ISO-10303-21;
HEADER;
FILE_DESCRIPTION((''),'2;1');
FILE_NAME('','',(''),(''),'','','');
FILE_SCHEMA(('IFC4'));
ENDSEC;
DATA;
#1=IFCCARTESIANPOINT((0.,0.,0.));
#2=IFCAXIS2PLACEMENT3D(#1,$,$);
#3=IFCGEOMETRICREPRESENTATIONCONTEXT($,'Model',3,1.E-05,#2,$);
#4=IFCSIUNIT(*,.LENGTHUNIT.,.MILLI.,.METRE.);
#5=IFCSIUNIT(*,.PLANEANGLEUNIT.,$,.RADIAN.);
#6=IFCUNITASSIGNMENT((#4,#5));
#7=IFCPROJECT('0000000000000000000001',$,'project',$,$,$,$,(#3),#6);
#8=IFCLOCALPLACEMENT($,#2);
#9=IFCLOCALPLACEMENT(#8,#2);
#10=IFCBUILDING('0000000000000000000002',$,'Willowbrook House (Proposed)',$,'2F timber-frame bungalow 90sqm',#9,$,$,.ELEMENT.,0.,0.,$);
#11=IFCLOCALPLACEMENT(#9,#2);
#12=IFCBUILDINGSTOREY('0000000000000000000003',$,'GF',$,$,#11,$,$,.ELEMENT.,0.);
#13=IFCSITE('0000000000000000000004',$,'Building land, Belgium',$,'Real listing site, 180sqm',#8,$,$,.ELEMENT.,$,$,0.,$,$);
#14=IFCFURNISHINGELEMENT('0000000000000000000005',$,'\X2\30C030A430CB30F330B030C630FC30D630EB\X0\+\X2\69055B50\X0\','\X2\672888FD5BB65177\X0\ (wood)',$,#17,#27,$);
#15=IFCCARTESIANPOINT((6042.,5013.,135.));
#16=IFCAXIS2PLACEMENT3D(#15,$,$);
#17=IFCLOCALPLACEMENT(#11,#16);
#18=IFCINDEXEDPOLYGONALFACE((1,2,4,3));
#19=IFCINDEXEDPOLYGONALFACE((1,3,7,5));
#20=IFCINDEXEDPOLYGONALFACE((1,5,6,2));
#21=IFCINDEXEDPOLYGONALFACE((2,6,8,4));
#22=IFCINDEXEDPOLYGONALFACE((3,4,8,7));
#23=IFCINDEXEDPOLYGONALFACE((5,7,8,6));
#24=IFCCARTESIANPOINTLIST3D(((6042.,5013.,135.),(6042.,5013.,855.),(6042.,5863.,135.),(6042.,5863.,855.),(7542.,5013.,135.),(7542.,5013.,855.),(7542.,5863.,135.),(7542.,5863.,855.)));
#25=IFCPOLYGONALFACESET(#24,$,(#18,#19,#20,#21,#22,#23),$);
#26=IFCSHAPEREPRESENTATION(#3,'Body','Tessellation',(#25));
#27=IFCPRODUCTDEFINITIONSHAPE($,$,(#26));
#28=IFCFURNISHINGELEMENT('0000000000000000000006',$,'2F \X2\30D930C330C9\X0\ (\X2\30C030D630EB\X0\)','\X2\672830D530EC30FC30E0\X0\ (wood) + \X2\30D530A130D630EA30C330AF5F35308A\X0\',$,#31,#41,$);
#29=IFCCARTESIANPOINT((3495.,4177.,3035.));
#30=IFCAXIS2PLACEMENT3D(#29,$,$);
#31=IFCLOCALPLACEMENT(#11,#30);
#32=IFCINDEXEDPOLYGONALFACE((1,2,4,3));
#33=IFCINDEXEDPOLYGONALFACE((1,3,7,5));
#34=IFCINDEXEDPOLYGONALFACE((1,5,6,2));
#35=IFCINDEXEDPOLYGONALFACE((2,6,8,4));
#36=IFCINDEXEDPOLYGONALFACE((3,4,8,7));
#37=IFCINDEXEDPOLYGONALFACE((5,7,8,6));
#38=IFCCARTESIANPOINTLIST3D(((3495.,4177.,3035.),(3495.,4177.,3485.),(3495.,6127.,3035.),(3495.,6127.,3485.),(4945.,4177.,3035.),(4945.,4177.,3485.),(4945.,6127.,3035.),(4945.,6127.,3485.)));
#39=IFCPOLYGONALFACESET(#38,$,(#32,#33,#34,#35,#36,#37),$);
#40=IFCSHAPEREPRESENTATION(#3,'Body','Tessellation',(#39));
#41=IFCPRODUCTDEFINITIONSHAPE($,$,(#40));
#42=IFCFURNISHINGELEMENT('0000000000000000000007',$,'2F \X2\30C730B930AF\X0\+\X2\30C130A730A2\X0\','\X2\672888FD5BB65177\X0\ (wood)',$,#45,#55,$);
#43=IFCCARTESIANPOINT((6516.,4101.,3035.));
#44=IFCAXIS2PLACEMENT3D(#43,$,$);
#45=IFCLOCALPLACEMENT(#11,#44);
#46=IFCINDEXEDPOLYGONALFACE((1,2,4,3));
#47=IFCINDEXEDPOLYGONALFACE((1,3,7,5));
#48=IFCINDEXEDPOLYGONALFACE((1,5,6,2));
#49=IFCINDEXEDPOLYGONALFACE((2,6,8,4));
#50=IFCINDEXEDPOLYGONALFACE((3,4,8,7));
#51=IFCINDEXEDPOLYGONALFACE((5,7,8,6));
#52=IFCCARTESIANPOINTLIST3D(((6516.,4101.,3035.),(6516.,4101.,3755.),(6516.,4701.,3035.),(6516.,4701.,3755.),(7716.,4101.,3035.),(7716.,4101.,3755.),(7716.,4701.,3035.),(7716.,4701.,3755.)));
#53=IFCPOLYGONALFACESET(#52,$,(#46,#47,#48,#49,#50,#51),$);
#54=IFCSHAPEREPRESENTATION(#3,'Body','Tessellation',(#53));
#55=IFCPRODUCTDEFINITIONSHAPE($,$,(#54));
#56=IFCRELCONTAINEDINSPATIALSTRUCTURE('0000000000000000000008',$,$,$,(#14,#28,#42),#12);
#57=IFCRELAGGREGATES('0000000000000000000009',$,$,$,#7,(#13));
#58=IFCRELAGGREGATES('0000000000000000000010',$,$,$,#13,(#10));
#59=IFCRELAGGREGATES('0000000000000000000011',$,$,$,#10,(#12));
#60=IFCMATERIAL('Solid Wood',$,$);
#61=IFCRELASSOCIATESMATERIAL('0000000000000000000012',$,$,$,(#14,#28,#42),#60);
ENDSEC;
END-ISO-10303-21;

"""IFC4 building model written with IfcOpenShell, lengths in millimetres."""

from ifc_helpers import new_model, si_unit, frame, frame_2d, origin, place, context, project, spatial, rectangle, extrude, material, element, save


model = new_model("IFC4")

# Units and contexts
model_context = context("Model", 3, precision=1e-05, world=origin())
ifc_project = project(units=[si_unit("LENGTHUNIT", "METRE", prefix="MILLI"), si_unit("PLANEANGLEUNIT", "RADIAN")], contexts=[model_context])

# Site, building, storey
site_placement = place(None, origin())
site = spatial("IfcSite", under=ifc_project, at=site_placement, Name="Building land, Belgium", ObjectType="Real listing site, 180sqm", CompositionType="ELEMENT", RefElevation=0.0)
building_placement = place(site_placement, origin())
building = spatial("IfcBuilding", under=site, at=building_placement, Name="Willowbrook House (Proposed)", ObjectType="2F timber-frame bungalow 90sqm", CompositionType="ELEMENT", ElevationOfRefHeight=0.0, ElevationOfTerrain=0.0)
storey_placement = place(building_placement, origin())
storey = spatial("IfcBuildingStorey", under=building, at=storey_placement, Name="GF", CompositionType="ELEMENT", Elevation=0.0)

# Shared definitions
ifc_material_1 = material(Name="Solid Wood")

# Furnishing elements
furnishing_1_placement = place(storey_placement, frame((6042.0, 5013.0, 135.0)))
element("IfcFurnishingElement", 1, at=furnishing_1_placement, inside=storey, material=ifc_material_1, Name="ダイニングテーブル+椅子", Description="木製家具 (wood)", context=model_context, shape_type="SweptSolid", body=[
    extrude(rectangle(XDim=1500.0, YDim=850.0, at=frame_2d((750.0, 425.0))), frame((6042.0, 5013.0, 135.0)), (0.0, 0.0, 1.0), 720.0),
])
furnishing_2_placement = place(storey_placement, frame((3495.0, 4177.0, 3035.0)))
element("IfcFurnishingElement", 2, at=furnishing_2_placement, inside=storey, material=ifc_material_1, Name="2F ベッド (ダブル)", Description="木フレーム (wood) + ファブリック張り", context=model_context, shape_type="SweptSolid", body=[
    extrude(rectangle(XDim=1450.0, YDim=1950.0, at=frame_2d((725.0, 975.0))), frame((3495.0, 4177.0, 3035.0)), (0.0, 0.0, 1.0), 450.0),
])
furnishing_3_placement = place(storey_placement, frame((6516.0, 4101.0, 3035.0)))
element("IfcFurnishingElement", 3, at=furnishing_3_placement, inside=storey, material=ifc_material_1, Name="2F デスク+チェア", Description="木製家具 (wood)", context=model_context, shape_type="SweptSolid", body=[
    extrude(rectangle(XDim=1200.0, YDim=600.0, at=frame_2d((600.0, 300.0))), frame((6516.0, 4101.0, 3035.0)), (0.0, 0.0, 1.0), 720.0),
])

save(model, "model.ifc")
